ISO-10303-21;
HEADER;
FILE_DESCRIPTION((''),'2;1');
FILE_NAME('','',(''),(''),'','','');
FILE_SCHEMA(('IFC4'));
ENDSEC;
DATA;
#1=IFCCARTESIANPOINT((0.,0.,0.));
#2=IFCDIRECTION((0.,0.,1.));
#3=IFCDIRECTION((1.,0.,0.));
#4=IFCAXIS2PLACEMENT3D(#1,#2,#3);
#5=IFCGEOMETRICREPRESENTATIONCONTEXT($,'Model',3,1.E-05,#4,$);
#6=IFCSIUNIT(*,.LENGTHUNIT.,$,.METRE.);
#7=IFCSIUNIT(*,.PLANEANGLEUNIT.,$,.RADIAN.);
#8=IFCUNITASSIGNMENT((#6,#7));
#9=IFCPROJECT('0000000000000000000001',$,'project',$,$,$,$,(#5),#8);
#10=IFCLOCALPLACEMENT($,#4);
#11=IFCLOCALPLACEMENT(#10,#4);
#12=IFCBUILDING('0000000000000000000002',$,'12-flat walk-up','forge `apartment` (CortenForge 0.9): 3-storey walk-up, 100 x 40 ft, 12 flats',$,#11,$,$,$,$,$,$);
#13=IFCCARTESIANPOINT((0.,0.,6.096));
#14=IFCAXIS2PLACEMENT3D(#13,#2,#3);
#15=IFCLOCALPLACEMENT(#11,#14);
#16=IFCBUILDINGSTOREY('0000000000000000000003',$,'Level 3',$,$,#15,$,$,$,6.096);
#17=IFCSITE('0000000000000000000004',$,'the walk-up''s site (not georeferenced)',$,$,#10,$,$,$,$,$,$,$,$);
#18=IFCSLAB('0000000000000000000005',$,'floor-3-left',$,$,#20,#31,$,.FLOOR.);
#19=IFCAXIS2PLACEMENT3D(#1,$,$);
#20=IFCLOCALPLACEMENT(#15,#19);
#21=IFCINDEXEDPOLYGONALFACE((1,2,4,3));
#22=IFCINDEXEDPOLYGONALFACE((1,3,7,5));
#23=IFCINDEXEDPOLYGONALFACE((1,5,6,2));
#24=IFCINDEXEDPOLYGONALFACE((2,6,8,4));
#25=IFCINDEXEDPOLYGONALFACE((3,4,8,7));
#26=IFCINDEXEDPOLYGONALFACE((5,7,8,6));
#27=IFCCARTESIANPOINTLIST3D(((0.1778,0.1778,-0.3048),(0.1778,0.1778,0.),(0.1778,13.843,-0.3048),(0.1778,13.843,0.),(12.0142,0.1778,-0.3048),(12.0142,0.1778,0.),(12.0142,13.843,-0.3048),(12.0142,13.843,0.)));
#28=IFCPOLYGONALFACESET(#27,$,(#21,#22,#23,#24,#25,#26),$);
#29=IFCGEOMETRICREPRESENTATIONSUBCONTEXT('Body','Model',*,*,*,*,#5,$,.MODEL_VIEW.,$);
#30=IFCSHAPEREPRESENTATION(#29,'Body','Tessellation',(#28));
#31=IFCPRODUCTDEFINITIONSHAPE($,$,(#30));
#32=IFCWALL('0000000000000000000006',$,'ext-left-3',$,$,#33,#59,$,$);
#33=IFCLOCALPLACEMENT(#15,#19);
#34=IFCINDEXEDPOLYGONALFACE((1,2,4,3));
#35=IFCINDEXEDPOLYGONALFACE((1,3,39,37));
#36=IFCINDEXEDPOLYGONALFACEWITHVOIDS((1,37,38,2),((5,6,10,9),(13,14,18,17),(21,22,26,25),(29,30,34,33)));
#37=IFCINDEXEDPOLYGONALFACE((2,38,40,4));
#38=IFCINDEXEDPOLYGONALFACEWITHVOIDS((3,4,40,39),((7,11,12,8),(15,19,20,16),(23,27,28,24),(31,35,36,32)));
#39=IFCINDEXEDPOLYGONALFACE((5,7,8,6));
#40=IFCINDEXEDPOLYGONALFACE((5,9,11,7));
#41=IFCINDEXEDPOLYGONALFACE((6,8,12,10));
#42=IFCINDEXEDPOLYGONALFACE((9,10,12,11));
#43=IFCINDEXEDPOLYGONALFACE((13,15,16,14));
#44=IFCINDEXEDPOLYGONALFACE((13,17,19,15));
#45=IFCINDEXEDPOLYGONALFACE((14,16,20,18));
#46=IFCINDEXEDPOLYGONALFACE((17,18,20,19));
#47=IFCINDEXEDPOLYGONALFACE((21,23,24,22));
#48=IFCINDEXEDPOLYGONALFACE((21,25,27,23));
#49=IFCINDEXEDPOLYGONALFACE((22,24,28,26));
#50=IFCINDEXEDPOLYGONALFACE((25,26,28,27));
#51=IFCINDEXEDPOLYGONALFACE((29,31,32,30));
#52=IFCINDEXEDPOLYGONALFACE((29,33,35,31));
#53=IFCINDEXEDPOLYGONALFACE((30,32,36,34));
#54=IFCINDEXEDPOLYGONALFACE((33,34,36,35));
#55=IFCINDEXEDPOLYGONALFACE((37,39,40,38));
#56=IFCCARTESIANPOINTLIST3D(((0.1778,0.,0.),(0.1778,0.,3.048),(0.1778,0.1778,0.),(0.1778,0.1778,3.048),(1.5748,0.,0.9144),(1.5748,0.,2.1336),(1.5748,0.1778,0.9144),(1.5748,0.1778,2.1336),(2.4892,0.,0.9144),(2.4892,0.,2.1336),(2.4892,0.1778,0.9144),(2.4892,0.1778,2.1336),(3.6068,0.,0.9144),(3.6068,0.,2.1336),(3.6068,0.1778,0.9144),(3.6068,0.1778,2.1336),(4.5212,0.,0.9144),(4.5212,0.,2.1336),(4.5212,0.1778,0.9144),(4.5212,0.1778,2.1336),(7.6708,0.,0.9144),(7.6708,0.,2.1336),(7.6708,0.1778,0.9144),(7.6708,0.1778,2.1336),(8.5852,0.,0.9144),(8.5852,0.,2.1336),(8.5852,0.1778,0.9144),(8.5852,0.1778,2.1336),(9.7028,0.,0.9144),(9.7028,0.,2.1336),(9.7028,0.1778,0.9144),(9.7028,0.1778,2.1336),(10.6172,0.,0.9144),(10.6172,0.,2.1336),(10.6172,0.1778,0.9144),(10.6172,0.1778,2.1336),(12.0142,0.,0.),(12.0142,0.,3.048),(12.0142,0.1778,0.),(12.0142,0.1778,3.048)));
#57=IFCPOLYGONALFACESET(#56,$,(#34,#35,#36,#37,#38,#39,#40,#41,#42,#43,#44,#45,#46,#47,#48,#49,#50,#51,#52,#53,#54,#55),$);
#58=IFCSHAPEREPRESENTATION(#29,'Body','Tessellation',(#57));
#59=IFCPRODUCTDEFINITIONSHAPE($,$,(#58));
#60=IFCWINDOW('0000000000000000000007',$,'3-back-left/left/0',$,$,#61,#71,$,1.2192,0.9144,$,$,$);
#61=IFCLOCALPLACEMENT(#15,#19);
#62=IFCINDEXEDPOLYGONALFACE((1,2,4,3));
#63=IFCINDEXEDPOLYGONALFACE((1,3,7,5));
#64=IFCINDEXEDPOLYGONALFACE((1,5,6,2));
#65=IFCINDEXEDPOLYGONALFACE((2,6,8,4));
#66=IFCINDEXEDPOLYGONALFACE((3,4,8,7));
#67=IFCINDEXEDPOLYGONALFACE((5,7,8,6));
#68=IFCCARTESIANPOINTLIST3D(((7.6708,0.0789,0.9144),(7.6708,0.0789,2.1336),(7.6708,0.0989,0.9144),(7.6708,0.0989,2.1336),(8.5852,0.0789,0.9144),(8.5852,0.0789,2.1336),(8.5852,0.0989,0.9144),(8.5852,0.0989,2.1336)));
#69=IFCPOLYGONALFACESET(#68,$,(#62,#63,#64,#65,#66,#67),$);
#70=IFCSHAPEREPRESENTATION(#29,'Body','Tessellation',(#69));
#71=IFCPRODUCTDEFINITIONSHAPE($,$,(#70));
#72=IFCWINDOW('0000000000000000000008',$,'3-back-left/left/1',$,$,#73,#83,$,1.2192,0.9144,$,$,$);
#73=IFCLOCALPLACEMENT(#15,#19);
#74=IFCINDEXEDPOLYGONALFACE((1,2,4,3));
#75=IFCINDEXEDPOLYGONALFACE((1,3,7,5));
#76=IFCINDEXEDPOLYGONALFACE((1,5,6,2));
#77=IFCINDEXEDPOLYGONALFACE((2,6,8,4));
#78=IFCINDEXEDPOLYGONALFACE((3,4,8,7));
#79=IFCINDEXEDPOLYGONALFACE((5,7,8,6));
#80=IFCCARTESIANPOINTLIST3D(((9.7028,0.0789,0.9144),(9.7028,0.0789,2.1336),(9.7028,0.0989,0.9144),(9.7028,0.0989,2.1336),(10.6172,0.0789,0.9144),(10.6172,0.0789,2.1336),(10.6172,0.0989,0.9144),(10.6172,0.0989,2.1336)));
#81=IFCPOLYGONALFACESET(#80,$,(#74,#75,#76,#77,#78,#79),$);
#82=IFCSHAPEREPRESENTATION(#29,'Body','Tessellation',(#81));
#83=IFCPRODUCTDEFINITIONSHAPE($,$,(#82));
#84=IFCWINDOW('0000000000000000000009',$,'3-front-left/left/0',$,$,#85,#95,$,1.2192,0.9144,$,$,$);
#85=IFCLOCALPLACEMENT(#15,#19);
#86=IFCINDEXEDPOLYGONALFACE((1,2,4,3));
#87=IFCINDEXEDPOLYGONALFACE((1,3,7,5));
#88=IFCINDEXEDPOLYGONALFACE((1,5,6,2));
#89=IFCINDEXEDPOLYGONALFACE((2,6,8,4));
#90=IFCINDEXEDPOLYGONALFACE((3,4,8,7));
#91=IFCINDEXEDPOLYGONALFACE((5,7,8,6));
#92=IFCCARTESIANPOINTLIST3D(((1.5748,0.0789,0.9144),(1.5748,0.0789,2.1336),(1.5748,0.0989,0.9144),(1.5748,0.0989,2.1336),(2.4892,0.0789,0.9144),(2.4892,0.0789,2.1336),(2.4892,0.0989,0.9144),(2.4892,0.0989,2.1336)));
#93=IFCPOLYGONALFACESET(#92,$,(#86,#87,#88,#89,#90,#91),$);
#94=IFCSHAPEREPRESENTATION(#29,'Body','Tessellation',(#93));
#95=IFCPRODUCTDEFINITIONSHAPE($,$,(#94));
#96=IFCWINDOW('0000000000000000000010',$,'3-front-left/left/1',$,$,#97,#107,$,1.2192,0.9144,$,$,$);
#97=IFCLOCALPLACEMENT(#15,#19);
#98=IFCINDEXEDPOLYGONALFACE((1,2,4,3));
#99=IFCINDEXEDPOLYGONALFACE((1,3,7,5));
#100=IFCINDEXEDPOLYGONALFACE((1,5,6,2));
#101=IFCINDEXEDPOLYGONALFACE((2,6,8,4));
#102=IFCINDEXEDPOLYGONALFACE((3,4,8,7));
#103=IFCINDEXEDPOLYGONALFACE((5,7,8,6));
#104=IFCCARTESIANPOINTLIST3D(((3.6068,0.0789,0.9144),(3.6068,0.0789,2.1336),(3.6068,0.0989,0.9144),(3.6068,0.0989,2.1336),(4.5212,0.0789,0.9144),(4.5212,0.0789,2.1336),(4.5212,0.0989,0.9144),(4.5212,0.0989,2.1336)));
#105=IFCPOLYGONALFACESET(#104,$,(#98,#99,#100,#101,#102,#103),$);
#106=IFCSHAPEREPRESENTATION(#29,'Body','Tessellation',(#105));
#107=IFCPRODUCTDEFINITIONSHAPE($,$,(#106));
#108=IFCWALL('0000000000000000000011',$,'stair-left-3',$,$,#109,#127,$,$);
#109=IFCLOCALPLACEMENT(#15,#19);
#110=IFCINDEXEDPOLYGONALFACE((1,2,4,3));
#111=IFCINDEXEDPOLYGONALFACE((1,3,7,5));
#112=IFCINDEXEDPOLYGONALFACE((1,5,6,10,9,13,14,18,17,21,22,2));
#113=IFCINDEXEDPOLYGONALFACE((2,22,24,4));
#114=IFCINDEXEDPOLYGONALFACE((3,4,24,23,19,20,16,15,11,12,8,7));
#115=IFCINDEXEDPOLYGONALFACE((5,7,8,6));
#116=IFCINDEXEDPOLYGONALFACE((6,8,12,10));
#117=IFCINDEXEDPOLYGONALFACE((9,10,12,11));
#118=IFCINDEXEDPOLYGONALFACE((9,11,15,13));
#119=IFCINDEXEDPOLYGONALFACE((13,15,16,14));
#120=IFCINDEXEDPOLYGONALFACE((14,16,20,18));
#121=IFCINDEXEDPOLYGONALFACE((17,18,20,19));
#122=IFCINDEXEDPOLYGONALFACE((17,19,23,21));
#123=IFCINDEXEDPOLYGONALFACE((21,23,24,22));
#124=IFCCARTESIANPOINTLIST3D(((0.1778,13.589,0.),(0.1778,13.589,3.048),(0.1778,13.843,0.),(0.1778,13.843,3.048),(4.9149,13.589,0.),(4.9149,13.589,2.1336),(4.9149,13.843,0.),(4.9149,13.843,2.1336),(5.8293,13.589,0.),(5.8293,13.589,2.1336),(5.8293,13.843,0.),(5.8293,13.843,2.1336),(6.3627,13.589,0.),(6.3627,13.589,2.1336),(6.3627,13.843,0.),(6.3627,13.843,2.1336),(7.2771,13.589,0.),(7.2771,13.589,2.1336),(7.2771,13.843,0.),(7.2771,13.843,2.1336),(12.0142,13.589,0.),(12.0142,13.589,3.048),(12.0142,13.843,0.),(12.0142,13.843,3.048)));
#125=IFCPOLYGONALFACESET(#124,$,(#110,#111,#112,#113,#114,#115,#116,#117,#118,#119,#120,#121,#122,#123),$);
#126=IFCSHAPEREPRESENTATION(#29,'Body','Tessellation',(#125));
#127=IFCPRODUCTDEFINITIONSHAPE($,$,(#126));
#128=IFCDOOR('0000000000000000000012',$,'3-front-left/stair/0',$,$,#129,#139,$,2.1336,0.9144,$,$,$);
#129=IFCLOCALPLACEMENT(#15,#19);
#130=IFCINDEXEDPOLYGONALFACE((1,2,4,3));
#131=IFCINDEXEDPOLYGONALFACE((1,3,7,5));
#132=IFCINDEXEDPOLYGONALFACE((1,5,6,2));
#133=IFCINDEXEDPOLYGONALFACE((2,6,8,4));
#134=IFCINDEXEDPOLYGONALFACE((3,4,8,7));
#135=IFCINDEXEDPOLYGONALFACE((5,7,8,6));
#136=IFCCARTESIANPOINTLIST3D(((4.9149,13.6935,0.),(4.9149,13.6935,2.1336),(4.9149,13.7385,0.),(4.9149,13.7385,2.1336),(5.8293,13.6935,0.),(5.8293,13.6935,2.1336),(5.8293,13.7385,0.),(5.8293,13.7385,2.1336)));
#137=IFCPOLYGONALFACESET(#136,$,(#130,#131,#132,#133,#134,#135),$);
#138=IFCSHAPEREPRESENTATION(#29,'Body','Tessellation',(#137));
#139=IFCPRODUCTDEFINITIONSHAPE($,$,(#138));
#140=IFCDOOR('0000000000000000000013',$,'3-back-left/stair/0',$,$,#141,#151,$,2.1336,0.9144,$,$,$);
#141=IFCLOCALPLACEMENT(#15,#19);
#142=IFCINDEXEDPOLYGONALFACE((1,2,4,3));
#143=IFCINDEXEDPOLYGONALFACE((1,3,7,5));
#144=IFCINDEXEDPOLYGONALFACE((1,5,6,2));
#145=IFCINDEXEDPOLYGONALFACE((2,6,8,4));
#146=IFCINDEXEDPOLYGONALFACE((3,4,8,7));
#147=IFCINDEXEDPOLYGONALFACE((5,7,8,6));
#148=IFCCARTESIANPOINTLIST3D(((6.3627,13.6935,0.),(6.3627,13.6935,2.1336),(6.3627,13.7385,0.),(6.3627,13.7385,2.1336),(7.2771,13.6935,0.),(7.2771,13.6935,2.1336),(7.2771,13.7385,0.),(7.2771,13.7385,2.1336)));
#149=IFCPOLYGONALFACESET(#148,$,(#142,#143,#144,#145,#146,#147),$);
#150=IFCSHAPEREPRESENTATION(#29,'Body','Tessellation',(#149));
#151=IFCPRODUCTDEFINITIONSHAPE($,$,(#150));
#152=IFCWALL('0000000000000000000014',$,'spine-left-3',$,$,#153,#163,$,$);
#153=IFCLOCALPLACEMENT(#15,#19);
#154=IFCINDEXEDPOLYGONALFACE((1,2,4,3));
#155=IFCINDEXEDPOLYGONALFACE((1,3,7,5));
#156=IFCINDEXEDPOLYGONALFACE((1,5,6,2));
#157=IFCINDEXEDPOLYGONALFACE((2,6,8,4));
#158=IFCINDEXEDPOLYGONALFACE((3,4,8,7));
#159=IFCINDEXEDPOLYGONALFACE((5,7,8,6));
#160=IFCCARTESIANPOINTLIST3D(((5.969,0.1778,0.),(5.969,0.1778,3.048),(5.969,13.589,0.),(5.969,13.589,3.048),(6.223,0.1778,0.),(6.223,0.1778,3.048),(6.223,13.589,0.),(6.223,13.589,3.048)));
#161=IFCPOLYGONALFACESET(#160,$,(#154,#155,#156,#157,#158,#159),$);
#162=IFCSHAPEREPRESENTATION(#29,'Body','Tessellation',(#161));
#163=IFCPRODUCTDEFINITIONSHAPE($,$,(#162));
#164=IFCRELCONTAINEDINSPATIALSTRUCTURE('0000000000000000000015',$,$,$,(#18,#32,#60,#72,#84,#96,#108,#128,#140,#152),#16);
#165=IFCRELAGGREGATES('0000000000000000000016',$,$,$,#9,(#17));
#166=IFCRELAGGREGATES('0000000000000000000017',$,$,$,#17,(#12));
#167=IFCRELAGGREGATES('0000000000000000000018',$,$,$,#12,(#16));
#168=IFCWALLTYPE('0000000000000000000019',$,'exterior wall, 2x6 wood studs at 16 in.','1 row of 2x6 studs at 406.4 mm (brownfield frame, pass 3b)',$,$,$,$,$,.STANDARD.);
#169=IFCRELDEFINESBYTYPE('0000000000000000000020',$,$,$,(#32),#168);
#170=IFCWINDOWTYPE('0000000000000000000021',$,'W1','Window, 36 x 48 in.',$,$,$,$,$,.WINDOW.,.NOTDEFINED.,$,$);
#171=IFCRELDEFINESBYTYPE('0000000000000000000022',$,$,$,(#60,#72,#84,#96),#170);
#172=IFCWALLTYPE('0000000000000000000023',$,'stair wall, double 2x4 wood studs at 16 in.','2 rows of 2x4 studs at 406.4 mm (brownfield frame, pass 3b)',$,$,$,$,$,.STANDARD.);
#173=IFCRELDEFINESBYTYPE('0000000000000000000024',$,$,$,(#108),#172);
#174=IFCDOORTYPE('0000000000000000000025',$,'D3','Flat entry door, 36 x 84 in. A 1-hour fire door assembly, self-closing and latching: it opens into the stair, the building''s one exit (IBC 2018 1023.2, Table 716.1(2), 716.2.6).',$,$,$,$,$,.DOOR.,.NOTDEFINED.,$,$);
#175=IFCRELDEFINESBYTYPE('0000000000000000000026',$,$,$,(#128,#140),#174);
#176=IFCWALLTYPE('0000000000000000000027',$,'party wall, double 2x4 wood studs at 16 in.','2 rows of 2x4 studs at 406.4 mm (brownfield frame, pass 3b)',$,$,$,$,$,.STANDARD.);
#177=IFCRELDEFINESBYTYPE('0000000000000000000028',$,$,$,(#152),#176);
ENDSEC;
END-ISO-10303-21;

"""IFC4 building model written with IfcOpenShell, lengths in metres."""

from ifc_helpers import new_model, si_unit, frame, frame_2d, origin, origin_with_axes, place, context, subcontext, project, spatial, rectangle, extrude, type_object, element, fill, save


model = new_model("IFC4")

# Units and contexts
model_context = context("Model", 3, precision=1e-05, world=origin_with_axes())
body_context = subcontext(model_context, "Body", "Model", "MODEL_VIEW")
ifc_project = project(units=[si_unit("LENGTHUNIT", "METRE"), si_unit("PLANEANGLEUNIT", "RADIAN")], contexts=[model_context])

# Site, building, storey
site_placement = place(None, origin_with_axes())
site = spatial("IfcSite", under=ifc_project, at=site_placement, Name="the walk-up's site (not georeferenced)")
building_placement = place(site_placement, origin_with_axes())
building = spatial("IfcBuilding", under=site, at=building_placement, Name="12-flat walk-up", Description="forge `apartment` (CortenForge 0.9): 3-storey walk-up, 100 x 40 ft, 12 flats")
storey_placement = place(building_placement, frame((0.0, 0.0, 6.096), z_axis=(0.0, 0.0, 1.0), x_axis=(1.0, 0.0, 0.0)))
storey = spatial("IfcBuildingStorey", under=building, at=storey_placement, Name="Level 3", Elevation=6.096)

# Slab
slab_placement = place(storey_placement, frame((0.1778, 0.1778, -0.3048), z_axis=(0.0, 0.0, 1.0), x_axis=(1.0, 0.0, 0.0)))
element("IfcSlab", 1, at=slab_placement, inside=storey, Name="floor-3-left", PredefinedType="FLOOR", context=body_context, shape_type="SweptSolid", body=[
    extrude(rectangle(XDim=11.8364, YDim=13.6652, at=frame_2d((5.9182, 6.8326))), origin(), (0.0, 0.0, 1.0), 0.3048),
])

# Wall, openings, windows
wall_type_1 = type_object("IfcWallType", Name="exterior wall, 2x6 wood studs at 16 in.", Description="1 row of 2x6 studs at 406.4 mm (brownfield frame, pass 3b)", PredefinedType="STANDARD")
wall_1_placement = place(storey_placement, frame((0.1778, 0.0, 0.0), z_axis=(0.0, 0.0, 1.0), x_axis=(1.0, 0.0, 0.0)))
wall_1 = element("IfcWall", 2, at=wall_1_placement, inside=storey, type_object=wall_type_1, Name="ext-left-3", context=body_context, shape_type="SweptSolid", body=[
    extrude(rectangle(XDim=11.8364, YDim=0.1778, at=frame_2d((5.9182, 0.0889))), origin(), (0.0, 0.0, 1.0), 3.048),
])
opening_1_placement = place(wall_1_placement, frame((7.493, 0.0, 0.9144), z_axis=(0.0, 0.0, 1.0), x_axis=(1.0, 0.0, 0.0)))
opening_1 = element("IfcOpeningElement", 3, at=opening_1_placement, cuts=wall_1, PredefinedType="OPENING", context=body_context, shape_type="SweptSolid", body=[
    extrude(rectangle(XDim=0.9144, YDim=0.1778, at=frame_2d((0.4572, 0.0889))), origin(), (0.0, 0.0, 1.0), 1.2192),
])
opening_2_placement = place(wall_1_placement, frame((9.525, 0.0, 0.9144), z_axis=(0.0, 0.0, 1.0), x_axis=(1.0, 0.0, 0.0)))
opening_2 = element("IfcOpeningElement", 4, at=opening_2_placement, cuts=wall_1, PredefinedType="OPENING", context=body_context, shape_type="SweptSolid", body=[
    extrude(rectangle(XDim=0.9144, YDim=0.1778, at=frame_2d((0.4572, 0.0889))), origin(), (0.0, 0.0, 1.0), 1.2192),
])
opening_3_placement = place(wall_1_placement, frame((1.397, 0.0, 0.9144), z_axis=(0.0, 0.0, 1.0), x_axis=(1.0, 0.0, 0.0)))
opening_3 = element("IfcOpeningElement", 5, at=opening_3_placement, cuts=wall_1, PredefinedType="OPENING", context=body_context, shape_type="SweptSolid", body=[
    extrude(rectangle(XDim=0.9144, YDim=0.1778, at=frame_2d((0.4572, 0.0889))), origin(), (0.0, 0.0, 1.0), 1.2192),
])
opening_4_placement = place(wall_1_placement, frame((3.429, 0.0, 0.9144), z_axis=(0.0, 0.0, 1.0), x_axis=(1.0, 0.0, 0.0)))
opening_4 = element("IfcOpeningElement", 6, at=opening_4_placement, cuts=wall_1, PredefinedType="OPENING", context=body_context, shape_type="SweptSolid", body=[
    extrude(rectangle(XDim=0.9144, YDim=0.1778, at=frame_2d((0.4572, 0.0889))), origin(), (0.0, 0.0, 1.0), 1.2192),
])
window_type = type_object("IfcWindowType", Name="W1", Description="Window, 36 x 48 in.", PartitioningType="NOTDEFINED", PredefinedType="WINDOW")
window_1_placement = place(opening_1_placement, frame((0.0, 0.0789, 0.0), z_axis=(0.0, 0.0, 1.0), x_axis=(1.0, 0.0, 0.0)))
window_1 = element("IfcWindow", 7, at=window_1_placement, inside=storey, type_object=window_type, Name="3-back-left/left/0", OverallHeight=1.2192, OverallWidth=0.9144, context=body_context, shape_type="SweptSolid", body=[
    extrude(rectangle(XDim=0.9144, YDim=0.02, at=frame_2d((0.4572, 0.01))), origin(), (0.0, 0.0, 1.0), 1.2192),
])
fill(opening_1, window_1)
window_2_placement = place(opening_2_placement, frame((0.0, 0.0789, 0.0), z_axis=(0.0, 0.0, 1.0), x_axis=(1.0, 0.0, 0.0)))
window_2 = element("IfcWindow", 8, at=window_2_placement, inside=storey, type_object=window_type, Name="3-back-left/left/1", OverallHeight=1.2192, OverallWidth=0.9144, context=body_context, shape_type="SweptSolid", body=[
    extrude(rectangle(XDim=0.9144, YDim=0.02, at=frame_2d((0.4572, 0.01))), origin(), (0.0, 0.0, 1.0), 1.2192),
])
fill(opening_2, window_2)
window_3_placement = place(opening_3_placement, frame((0.0, 0.0789, 0.0), z_axis=(0.0, 0.0, 1.0), x_axis=(1.0, 0.0, 0.0)))
window_3 = element("IfcWindow", 9, at=window_3_placement, inside=storey, type_object=window_type, Name="3-front-left/left/0", OverallHeight=1.2192, OverallWidth=0.9144, context=body_context, shape_type="SweptSolid", body=[
    extrude(rectangle(XDim=0.9144, YDim=0.02, at=frame_2d((0.4572, 0.01))), origin(), (0.0, 0.0, 1.0), 1.2192),
])
fill(opening_3, window_3)
window_4_placement = place(opening_4_placement, frame((0.0, 0.0789, 0.0), z_axis=(0.0, 0.0, 1.0), x_axis=(1.0, 0.0, 0.0)))
window_4 = element("IfcWindow", 10, at=window_4_placement, inside=storey, type_object=window_type, Name="3-front-left/left/1", OverallHeight=1.2192, OverallWidth=0.9144, context=body_context, shape_type="SweptSolid", body=[
    extrude(rectangle(XDim=0.9144, YDim=0.02, at=frame_2d((0.4572, 0.01))), origin(), (0.0, 0.0, 1.0), 1.2192),
])
fill(opening_4, window_4)

# Wall, openings, doors
wall_type_2 = type_object("IfcWallType", Name="stair wall, double 2x4 wood studs at 16 in.", Description="2 rows of 2x4 studs at 406.4 mm (brownfield frame, pass 3b)", PredefinedType="STANDARD")
wall_2_placement = place(storey_placement, frame((0.1778, 13.589, 0.0), z_axis=(0.0, 0.0, 1.0), x_axis=(1.0, 0.0, 0.0)))
wall_2 = element("IfcWall", 11, at=wall_2_placement, inside=storey, type_object=wall_type_2, Name="stair-left-3", context=body_context, shape_type="SweptSolid", body=[
    extrude(rectangle(XDim=11.8364, YDim=0.254, at=frame_2d((5.9182, 0.127))), origin(), (0.0, 0.0, 1.0), 3.048),
])
opening_5_placement = place(wall_2_placement, frame((4.7371, 0.0, 0.0), z_axis=(0.0, 0.0, 1.0), x_axis=(1.0, 0.0, 0.0)))
opening_5 = element("IfcOpeningElement", 12, at=opening_5_placement, cuts=wall_2, PredefinedType="OPENING", context=body_context, shape_type="SweptSolid", body=[
    extrude(rectangle(XDim=0.9144, YDim=0.254, at=frame_2d((0.4572, 0.127))), origin(), (0.0, 0.0, 1.0), 2.1336),
])
opening_6_placement = place(wall_2_placement, frame((6.1849, 0.0, 0.0), z_axis=(0.0, 0.0, 1.0), x_axis=(1.0, 0.0, 0.0)))
opening_6 = element("IfcOpeningElement", 13, at=opening_6_placement, cuts=wall_2, PredefinedType="OPENING", context=body_context, shape_type="SweptSolid", body=[
    extrude(rectangle(XDim=0.9144, YDim=0.254, at=frame_2d((0.4572, 0.127))), origin(), (0.0, 0.0, 1.0), 2.1336),
])
door_type = type_object("IfcDoorType", Name="D3", Description="Flat entry door, 36 x 84 in. A 1-hour fire door assembly, self-closing and latching: it opens into the stair, the building's one exit (IBC 2018 1023.2, Table 716.1(2), 716.2.6).", OperationType="NOTDEFINED", PredefinedType="DOOR")
door_1_placement = place(opening_5_placement, frame((0.0, 0.1045, 0.0), z_axis=(0.0, 0.0, 1.0), x_axis=(1.0, 0.0, 0.0)))
door_1 = element("IfcDoor", 14, at=door_1_placement, inside=storey, type_object=door_type, Name="3-front-left/stair/0", OverallHeight=2.1336, OverallWidth=0.9144, context=body_context, shape_type="SweptSolid", body=[
    extrude(rectangle(XDim=0.9144, YDim=0.045, at=frame_2d((0.4572, 0.0225))), origin(), (0.0, 0.0, 1.0), 2.1336),
])
fill(opening_5, door_1)
door_2_placement = place(opening_6_placement, frame((0.0, 0.1045, 0.0), z_axis=(0.0, 0.0, 1.0), x_axis=(1.0, 0.0, 0.0)))
door_2 = element("IfcDoor", 15, at=door_2_placement, inside=storey, type_object=door_type, Name="3-back-left/stair/0", OverallHeight=2.1336, OverallWidth=0.9144, context=body_context, shape_type="SweptSolid", body=[
    extrude(rectangle(XDim=0.9144, YDim=0.045, at=frame_2d((0.4572, 0.0225))), origin(), (0.0, 0.0, 1.0), 2.1336),
])
fill(opening_6, door_2)

# Wall
wall_type_3 = type_object("IfcWallType", Name="party wall, double 2x4 wood studs at 16 in.", Description="2 rows of 2x4 studs at 406.4 mm (brownfield frame, pass 3b)", PredefinedType="STANDARD")
wall_3_placement = place(storey_placement, frame((5.969, 0.1778, 0.0), z_axis=(0.0, 0.0, 1.0), x_axis=(1.0, 0.0, 0.0)))
element("IfcWall", 16, at=wall_3_placement, inside=storey, type_object=wall_type_3, Name="spine-left-3", context=body_context, shape_type="SweptSolid", body=[
    extrude(rectangle(XDim=0.254, YDim=13.4112, at=frame_2d((0.127, 6.7056))), origin(), (0.0, 0.0, 1.0), 3.048),
])

save(model, "model.ifc")
